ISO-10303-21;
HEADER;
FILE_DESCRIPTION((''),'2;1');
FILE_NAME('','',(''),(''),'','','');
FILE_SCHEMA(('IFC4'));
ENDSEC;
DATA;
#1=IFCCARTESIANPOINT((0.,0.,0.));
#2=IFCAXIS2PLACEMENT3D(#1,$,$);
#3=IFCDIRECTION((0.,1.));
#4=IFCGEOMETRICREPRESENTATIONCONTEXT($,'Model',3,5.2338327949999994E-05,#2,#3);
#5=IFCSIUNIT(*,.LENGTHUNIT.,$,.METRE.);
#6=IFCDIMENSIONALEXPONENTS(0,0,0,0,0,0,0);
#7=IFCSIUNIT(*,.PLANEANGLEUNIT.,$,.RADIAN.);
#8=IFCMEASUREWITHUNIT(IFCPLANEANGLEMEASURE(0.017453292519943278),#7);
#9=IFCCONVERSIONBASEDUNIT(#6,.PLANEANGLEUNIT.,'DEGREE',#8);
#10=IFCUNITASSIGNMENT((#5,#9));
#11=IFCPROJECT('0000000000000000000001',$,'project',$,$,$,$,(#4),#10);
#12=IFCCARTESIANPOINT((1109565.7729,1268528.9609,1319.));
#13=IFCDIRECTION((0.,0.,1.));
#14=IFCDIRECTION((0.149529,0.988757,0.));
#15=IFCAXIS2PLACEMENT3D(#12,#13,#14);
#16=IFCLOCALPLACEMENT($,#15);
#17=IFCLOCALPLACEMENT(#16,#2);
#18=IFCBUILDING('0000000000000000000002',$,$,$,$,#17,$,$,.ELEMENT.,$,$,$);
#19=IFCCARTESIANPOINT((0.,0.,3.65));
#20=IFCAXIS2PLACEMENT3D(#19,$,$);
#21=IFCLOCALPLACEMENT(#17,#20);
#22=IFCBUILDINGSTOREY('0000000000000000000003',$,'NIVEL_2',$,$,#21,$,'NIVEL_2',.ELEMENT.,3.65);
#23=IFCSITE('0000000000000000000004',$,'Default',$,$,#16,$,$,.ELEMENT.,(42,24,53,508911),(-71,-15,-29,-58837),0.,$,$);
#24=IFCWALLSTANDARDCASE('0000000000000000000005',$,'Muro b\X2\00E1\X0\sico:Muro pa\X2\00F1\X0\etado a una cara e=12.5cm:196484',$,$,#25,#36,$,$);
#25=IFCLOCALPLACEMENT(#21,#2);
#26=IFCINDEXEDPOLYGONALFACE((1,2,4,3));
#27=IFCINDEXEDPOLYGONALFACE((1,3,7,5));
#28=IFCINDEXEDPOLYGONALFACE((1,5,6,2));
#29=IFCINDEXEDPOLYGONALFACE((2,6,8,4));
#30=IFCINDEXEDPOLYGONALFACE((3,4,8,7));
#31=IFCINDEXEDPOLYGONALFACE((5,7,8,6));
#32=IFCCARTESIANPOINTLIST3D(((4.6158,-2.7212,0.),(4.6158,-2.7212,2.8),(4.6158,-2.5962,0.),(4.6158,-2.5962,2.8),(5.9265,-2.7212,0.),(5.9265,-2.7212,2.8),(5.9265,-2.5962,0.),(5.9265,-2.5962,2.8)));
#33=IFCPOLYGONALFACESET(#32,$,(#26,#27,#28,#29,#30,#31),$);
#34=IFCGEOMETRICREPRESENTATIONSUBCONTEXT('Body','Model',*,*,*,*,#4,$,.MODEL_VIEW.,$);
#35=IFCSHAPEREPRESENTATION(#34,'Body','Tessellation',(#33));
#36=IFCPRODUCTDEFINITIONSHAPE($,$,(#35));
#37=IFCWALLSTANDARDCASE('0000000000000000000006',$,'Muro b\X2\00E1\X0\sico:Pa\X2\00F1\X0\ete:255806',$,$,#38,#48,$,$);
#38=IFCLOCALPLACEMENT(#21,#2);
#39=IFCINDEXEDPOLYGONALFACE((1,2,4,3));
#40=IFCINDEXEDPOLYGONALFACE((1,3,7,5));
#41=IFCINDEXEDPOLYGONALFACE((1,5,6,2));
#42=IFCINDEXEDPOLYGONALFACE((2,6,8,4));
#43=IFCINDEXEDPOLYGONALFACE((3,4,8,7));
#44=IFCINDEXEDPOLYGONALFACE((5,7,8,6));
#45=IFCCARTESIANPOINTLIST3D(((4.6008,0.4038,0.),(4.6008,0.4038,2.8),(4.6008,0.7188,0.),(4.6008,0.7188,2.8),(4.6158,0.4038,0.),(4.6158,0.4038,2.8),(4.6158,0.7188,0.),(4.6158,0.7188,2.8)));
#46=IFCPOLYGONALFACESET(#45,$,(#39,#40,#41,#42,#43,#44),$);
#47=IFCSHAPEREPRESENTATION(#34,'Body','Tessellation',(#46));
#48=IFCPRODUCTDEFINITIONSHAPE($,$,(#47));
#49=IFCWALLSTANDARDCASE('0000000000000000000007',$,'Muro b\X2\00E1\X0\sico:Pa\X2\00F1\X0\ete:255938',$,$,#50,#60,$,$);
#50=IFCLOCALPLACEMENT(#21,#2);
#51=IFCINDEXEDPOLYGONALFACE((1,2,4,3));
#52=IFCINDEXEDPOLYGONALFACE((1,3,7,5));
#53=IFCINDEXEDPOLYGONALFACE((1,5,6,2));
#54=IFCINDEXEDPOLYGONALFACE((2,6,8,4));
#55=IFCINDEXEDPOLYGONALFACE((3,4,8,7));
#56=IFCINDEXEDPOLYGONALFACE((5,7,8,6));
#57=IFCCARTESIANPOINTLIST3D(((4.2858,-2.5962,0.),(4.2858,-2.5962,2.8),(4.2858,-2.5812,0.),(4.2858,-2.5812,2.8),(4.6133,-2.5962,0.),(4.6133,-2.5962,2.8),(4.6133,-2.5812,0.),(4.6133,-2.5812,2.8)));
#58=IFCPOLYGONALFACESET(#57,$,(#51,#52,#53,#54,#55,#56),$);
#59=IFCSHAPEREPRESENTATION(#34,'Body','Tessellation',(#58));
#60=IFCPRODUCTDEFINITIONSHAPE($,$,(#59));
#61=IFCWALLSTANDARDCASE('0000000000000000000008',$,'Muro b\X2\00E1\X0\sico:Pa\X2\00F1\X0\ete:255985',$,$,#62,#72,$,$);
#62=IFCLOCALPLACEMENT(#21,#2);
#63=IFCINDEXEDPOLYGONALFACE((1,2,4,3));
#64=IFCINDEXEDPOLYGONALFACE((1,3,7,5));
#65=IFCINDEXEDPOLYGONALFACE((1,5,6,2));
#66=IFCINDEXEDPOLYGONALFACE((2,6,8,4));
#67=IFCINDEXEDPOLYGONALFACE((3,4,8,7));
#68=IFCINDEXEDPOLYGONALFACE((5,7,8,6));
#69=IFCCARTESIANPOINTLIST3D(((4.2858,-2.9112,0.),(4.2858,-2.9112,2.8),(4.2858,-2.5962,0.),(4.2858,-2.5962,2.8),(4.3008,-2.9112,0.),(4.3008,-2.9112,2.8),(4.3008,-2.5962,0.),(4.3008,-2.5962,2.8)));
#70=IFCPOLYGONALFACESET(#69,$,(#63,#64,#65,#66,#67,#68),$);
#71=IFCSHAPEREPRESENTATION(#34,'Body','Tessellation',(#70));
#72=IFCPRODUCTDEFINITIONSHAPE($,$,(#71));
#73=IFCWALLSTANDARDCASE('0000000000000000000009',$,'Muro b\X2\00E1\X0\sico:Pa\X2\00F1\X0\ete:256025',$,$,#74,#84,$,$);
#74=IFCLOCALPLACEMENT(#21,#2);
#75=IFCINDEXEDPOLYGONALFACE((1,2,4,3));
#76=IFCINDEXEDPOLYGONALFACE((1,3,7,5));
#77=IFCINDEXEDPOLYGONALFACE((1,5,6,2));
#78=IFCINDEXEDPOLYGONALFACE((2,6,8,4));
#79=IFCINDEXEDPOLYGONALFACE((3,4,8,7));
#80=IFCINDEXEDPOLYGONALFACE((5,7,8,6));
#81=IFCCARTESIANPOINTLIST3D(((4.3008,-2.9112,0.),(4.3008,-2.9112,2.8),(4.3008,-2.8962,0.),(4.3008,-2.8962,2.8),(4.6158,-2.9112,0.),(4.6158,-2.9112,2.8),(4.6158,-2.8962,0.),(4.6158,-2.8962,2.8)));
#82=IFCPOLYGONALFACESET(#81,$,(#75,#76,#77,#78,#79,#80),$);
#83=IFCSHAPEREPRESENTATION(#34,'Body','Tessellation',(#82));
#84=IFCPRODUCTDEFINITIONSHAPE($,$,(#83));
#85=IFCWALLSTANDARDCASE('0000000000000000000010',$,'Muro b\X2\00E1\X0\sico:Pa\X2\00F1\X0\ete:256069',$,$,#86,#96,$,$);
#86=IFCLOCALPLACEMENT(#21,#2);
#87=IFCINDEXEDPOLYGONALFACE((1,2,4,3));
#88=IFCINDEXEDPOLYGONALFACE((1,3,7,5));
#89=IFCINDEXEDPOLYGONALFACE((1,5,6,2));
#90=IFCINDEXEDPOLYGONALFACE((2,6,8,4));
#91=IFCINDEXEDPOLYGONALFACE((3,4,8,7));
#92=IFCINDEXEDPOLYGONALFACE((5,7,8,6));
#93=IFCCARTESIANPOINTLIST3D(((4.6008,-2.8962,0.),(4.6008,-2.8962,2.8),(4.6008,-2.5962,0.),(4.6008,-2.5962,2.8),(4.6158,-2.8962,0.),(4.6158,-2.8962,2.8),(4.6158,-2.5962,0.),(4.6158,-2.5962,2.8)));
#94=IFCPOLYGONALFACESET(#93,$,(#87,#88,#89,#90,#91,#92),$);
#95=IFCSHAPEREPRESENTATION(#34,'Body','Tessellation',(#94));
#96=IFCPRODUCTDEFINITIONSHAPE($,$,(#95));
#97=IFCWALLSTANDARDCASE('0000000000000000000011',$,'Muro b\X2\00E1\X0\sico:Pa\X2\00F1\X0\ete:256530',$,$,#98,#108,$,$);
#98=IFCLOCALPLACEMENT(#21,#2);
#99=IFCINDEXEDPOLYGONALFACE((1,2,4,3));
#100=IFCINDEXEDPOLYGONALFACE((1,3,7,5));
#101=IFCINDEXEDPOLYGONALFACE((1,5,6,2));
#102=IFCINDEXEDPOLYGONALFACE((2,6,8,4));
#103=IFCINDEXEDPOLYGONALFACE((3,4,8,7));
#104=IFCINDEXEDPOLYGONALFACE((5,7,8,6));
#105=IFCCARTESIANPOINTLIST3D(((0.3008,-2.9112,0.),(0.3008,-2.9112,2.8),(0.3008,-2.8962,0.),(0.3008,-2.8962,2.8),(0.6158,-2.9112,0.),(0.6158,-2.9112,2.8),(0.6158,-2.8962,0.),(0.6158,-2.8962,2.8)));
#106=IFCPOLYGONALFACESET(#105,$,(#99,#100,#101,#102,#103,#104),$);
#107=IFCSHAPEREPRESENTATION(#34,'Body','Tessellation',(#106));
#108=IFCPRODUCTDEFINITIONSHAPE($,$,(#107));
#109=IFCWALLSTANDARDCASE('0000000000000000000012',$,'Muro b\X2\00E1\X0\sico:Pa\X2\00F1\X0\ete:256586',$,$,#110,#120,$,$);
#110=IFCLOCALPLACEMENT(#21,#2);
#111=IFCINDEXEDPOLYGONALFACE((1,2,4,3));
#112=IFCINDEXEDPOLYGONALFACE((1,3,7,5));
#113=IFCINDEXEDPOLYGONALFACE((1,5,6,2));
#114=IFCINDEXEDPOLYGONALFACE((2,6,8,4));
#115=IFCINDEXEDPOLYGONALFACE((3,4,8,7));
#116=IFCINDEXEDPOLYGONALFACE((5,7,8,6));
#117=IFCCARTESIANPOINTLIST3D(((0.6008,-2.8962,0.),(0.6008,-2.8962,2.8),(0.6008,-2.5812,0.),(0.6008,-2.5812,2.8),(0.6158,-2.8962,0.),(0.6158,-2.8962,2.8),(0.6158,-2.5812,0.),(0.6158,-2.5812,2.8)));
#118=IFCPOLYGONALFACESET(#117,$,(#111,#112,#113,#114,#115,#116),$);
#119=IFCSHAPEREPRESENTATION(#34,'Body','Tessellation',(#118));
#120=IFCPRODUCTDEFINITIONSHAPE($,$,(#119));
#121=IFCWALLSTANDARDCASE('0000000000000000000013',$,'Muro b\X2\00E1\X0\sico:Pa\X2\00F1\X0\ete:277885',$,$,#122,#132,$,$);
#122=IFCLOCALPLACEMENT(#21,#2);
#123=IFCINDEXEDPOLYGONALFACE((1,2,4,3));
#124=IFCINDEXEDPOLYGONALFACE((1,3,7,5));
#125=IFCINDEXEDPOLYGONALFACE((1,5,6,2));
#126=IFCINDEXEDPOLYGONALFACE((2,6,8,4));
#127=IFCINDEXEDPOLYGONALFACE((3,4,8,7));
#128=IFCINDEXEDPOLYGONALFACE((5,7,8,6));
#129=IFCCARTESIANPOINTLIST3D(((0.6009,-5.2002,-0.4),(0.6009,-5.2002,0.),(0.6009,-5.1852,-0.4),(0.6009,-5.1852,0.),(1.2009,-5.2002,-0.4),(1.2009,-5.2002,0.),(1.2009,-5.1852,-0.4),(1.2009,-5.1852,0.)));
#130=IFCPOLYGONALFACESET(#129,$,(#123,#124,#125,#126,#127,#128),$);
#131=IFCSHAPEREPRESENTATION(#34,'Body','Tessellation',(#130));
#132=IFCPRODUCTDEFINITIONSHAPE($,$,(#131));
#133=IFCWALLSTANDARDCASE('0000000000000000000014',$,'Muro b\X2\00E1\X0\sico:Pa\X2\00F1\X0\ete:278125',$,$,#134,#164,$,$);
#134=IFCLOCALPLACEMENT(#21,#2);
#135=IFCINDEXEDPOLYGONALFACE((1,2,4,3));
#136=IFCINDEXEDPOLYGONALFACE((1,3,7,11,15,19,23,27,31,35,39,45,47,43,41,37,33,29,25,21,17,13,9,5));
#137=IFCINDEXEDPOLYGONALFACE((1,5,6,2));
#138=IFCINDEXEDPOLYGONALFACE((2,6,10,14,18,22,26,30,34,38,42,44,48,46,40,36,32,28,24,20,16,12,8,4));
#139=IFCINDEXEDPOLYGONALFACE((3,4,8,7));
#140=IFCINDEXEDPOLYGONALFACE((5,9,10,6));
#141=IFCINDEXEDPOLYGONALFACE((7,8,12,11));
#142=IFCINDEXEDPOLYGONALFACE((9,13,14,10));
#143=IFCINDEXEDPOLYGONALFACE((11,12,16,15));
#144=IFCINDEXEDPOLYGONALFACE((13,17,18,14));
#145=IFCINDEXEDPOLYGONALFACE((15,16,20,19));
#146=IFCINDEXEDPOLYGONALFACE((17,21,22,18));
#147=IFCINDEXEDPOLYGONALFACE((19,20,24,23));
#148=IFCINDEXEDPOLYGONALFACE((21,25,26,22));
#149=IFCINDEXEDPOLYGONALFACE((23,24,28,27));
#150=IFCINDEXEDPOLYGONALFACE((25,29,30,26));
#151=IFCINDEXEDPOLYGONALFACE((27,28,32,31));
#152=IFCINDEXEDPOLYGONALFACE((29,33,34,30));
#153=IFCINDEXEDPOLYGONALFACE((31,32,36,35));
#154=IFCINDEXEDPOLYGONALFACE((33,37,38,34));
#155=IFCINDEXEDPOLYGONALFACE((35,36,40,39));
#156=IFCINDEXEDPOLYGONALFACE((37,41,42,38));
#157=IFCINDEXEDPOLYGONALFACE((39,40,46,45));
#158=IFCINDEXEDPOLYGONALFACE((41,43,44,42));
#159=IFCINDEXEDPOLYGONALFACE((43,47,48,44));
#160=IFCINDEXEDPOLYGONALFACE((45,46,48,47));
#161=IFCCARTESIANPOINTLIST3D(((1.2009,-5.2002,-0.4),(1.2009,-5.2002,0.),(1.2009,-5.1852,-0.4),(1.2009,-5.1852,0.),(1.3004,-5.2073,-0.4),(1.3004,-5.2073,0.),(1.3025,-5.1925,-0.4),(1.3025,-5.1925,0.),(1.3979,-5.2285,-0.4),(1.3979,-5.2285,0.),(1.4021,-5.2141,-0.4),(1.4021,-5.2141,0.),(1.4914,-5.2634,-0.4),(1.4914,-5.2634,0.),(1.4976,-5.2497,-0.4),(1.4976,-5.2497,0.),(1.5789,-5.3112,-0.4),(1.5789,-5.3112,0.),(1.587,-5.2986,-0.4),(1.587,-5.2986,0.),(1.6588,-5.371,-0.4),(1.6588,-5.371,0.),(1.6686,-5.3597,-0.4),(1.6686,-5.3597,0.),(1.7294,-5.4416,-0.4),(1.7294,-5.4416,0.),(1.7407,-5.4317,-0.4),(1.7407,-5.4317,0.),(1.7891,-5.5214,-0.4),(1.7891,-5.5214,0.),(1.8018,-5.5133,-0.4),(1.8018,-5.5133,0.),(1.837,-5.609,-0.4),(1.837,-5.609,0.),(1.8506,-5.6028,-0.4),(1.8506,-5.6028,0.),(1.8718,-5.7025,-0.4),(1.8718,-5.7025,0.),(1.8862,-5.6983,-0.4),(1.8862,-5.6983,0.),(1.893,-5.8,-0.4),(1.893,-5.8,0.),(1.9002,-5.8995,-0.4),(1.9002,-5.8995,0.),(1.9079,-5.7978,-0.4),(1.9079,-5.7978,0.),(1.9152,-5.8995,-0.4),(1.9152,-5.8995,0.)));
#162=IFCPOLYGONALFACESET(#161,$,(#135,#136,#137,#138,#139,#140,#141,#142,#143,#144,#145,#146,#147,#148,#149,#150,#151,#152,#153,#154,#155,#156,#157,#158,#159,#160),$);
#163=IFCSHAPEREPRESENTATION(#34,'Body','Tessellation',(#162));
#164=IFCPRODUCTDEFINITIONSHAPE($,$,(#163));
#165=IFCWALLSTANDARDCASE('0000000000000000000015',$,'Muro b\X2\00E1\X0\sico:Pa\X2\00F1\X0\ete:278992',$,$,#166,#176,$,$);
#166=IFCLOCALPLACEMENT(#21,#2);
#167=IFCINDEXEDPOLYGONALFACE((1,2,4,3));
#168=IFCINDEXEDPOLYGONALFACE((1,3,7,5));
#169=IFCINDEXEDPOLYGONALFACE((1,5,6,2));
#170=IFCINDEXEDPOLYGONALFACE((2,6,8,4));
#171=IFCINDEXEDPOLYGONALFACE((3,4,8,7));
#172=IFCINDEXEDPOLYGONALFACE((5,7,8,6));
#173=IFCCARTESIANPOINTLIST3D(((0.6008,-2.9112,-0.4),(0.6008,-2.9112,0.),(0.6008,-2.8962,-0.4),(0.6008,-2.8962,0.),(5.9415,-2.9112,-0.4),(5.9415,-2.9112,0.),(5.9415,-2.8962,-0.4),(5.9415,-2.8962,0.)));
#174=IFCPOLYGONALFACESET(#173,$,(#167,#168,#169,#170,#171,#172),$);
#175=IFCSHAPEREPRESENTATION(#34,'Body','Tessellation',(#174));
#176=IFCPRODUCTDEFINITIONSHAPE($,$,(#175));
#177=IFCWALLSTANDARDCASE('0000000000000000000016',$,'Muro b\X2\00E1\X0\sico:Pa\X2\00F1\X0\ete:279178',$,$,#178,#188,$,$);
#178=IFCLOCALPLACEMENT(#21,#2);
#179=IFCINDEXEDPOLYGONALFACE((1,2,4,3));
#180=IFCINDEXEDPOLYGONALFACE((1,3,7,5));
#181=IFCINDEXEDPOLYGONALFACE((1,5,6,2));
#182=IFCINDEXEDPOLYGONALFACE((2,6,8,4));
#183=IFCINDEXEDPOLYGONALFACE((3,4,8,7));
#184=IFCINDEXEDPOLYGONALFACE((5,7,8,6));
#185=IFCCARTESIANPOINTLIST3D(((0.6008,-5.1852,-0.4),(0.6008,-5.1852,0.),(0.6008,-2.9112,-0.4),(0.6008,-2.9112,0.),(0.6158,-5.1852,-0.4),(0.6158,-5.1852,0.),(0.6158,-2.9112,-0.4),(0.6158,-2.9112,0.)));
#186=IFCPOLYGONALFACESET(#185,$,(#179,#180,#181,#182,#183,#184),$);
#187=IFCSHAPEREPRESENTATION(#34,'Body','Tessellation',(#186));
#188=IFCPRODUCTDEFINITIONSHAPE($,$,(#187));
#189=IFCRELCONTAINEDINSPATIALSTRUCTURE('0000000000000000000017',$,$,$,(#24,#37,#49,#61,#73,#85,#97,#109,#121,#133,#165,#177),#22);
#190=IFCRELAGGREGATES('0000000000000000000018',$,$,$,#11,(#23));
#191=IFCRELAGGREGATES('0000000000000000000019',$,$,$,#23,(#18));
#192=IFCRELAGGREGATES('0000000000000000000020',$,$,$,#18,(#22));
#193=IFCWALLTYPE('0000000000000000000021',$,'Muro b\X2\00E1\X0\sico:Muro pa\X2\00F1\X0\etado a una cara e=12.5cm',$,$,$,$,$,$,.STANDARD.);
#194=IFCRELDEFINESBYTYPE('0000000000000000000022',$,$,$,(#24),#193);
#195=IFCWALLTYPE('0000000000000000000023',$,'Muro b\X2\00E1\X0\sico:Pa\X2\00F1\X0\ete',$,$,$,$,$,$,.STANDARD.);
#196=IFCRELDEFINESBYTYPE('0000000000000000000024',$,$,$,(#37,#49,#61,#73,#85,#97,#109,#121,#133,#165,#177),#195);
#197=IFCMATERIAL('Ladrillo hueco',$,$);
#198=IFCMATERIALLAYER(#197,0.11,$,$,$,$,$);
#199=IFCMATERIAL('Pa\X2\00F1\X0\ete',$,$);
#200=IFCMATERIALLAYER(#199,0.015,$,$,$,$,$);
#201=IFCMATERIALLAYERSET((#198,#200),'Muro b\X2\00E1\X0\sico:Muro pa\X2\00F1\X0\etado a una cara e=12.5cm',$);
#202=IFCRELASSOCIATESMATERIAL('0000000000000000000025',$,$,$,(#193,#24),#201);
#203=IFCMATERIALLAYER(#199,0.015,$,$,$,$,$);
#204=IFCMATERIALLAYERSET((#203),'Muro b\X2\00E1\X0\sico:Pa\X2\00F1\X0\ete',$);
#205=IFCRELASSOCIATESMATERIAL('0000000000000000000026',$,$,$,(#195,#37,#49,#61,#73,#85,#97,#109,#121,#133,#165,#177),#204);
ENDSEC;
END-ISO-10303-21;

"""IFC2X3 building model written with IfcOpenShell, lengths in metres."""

from ifc_helpers import new_model, entity, si_unit, converted_unit, direction, frame, frame_2d, origin, place, context, subcontext, project, spatial, polyline, circle_curve, parameter, trimmed, segment, composite_curve, rectangle, outline, extrude, material, layer, layer_set, layer_usage, type_object, element, save


model = new_model("IFC2X3")

# Units and contexts
model_context = context("Model", 3, precision=5.2338327949999994e-05, world=origin(), true_north=direction((0.0, 1.0)))
body_context = subcontext(model_context, "Body", "Model", "MODEL_VIEW")
ifc_project = project(units=[si_unit("LENGTHUNIT", "METRE"), converted_unit("PLANEANGLEUNIT", "DEGREE", entity("IfcPlaneAngleMeasure", 0.017453292519943278), si_unit("PLANEANGLEUNIT", "RADIAN"), dimensions=[0, 0, 0, 0, 0, 0, 0])], contexts=[model_context])

# Site, building, storey
site_placement = place(None, frame((1109565.7729, 1268528.9609, 1319.0), z_axis=(0.0, 0.0, 1.0), x_axis=(0.149529, 0.988757, 0.0)))
site = spatial("IfcSite", under=ifc_project, at=site_placement, Name="Default", CompositionType="ELEMENT", RefLatitude=(42, 24, 53, 508911), RefLongitude=(-71, -15, -29, -58837), RefElevation=0.0)
building_placement = place(site_placement, origin())
building = spatial("IfcBuilding", under=site, at=building_placement, CompositionType="ELEMENT")
storey_placement = place(building_placement, frame((0.0, 0.0, 3.65)))
storey = spatial("IfcBuildingStorey", under=building, at=storey_placement, Name="NIVEL_2", LongName="NIVEL_2", CompositionType="ELEMENT", Elevation=3.65)

# Walls
ifc_material_1 = material(Name="Ladrillo hueco")
ifc_layer_1 = layer(ifc_material_1, 0.11)
ifc_material_2 = material(Name="Pañete")
ifc_layer_2 = layer(ifc_material_2, 0.015)
ifc_layer_set_1 = layer_set([ifc_layer_1, ifc_layer_2], Name="Muro básico:Muro pañetado a una cara e=12.5cm")
ifc_layer_usage_1 = layer_usage(ifc_layer_set_1, "AXIS2", "POSITIVE", -0.0625)
wall_type_1 = type_object("IfcWallType", Name="Muro básico:Muro pañetado a una cara e=12.5cm", PredefinedType="STANDARD", material=ifc_layer_set_1)
wall_1_placement = place(storey_placement, frame((5.9265, -2.6587, 0.0), z_axis=(0.0, 0.0, 1.0), x_axis=(-1.0, 0.000015, 0.0)))
element("IfcWallStandardCase", 1, at=wall_1_placement, inside=storey, type_object=wall_type_1, material=ifc_layer_usage_1, Name="Muro básico:Muro pañetado a una cara e=12.5cm:196484", context=body_context, shape_type="SweptSolid", body=[
    extrude(rectangle(XDim=1.3107, YDim=0.125, at=frame_2d((0.6554, 0.0), x_axis=(-1.0, 0.0))), origin(), (0.0, 0.0, 1.0), 2.8),
])
ifc_layer_3 = layer(ifc_material_2, 0.015)
ifc_layer_set_2 = layer_set([ifc_layer_3], Name="Muro básico:Pañete")
ifc_layer_usage_2 = layer_usage(ifc_layer_set_2, "AXIS2", "POSITIVE", -0.0075)
wall_type_2 = type_object("IfcWallType", Name="Muro básico:Pañete", PredefinedType="STANDARD", material=ifc_layer_set_2)
wall_2_placement = place(storey_placement, frame((4.6083, 0.4038, 0.0), z_axis=(0.0, 0.0, 1.0), x_axis=(0.0, 1.0, 0.0)))
element("IfcWallStandardCase", 2, at=wall_2_placement, inside=storey, type_object=wall_type_2, material=ifc_layer_usage_2, Name="Muro básico:Pañete:255806", context=body_context, shape_type="SweptSolid", body=[
    extrude(rectangle(XDim=0.315, YDim=0.015, at=frame_2d((0.1575, 0.0), x_axis=(-1.0, 0.0))), origin(), (0.0, 0.0, 1.0), 2.8),
])
ifc_layer_usage_3 = layer_usage(ifc_layer_set_2, "AXIS2", "POSITIVE", -0.0075)
wall_3_placement = place(storey_placement, frame((4.6133, -2.5887, 0.0), z_axis=(0.0, 0.0, 1.0), x_axis=(-1.0, 0.0, 0.0)))
element("IfcWallStandardCase", 3, at=wall_3_placement, inside=storey, type_object=wall_type_2, material=ifc_layer_usage_3, Name="Muro básico:Pañete:255938", context=body_context, shape_type="SweptSolid", body=[
    extrude(rectangle(XDim=0.3275, YDim=0.015, at=frame_2d((0.1638, 0.0), x_axis=(-1.0, 0.0))), origin(), (0.0, 0.0, 1.0), 2.8),
])
ifc_layer_usage_4 = layer_usage(ifc_layer_set_2, "AXIS2", "POSITIVE", -0.0075)
wall_4_placement = place(storey_placement, frame((4.2933, -2.5962, 0.0), z_axis=(0.0, 0.0, 1.0), x_axis=(0.0, -1.0, 0.0)))
element("IfcWallStandardCase", 4, at=wall_4_placement, inside=storey, type_object=wall_type_2, material=ifc_layer_usage_4, Name="Muro básico:Pañete:255985", context=body_context, shape_type="SweptSolid", body=[
    extrude(rectangle(XDim=0.315, YDim=0.015, at=frame_2d((0.1575, 0.0), x_axis=(-1.0, 0.0))), origin(), (0.0, 0.0, 1.0), 2.8),
])
ifc_layer_usage_5 = layer_usage(ifc_layer_set_2, "AXIS2", "POSITIVE", -0.0075)
wall_5_placement = place(storey_placement, frame((4.3008, -2.9037, 0.0)))
element("IfcWallStandardCase", 5, at=wall_5_placement, inside=storey, type_object=wall_type_2, material=ifc_layer_usage_5, Name="Muro básico:Pañete:256025", context=body_context, shape_type="SweptSolid", body=[
    extrude(rectangle(XDim=0.315, YDim=0.015, at=frame_2d((0.1575, 0.0), x_axis=(-1.0, 0.0))), origin(), (0.0, 0.0, 1.0), 2.8),
])
ifc_layer_usage_6 = layer_usage(ifc_layer_set_2, "AXIS2", "POSITIVE", -0.0075)
wall_6_placement = place(storey_placement, frame((4.6083, -2.8962, 0.0), z_axis=(0.0, 0.0, 1.0), x_axis=(0.0, 1.0, 0.0)))
element("IfcWallStandardCase", 6, at=wall_6_placement, inside=storey, type_object=wall_type_2, material=ifc_layer_usage_6, Name="Muro básico:Pañete:256069", context=body_context, shape_type="SweptSolid", body=[
    extrude(rectangle(XDim=0.3, YDim=0.015, at=frame_2d((0.15, 0.0), x_axis=(-1.0, 0.0))), origin(), (0.0, 0.0, 1.0), 2.8),
])
ifc_layer_usage_7 = layer_usage(ifc_layer_set_2, "AXIS2", "POSITIVE", -0.0075)
wall_7_placement = place(storey_placement, frame((0.3008, -2.9037, 0.0)))
element("IfcWallStandardCase", 7, at=wall_7_placement, inside=storey, type_object=wall_type_2, material=ifc_layer_usage_7, Name="Muro básico:Pañete:256530", context=body_context, shape_type="SweptSolid", body=[
    extrude(rectangle(XDim=0.315, YDim=0.015, at=frame_2d((0.1575, 0.0), x_axis=(-1.0, 0.0))), origin(), (0.0, 0.0, 1.0), 2.8),
])
ifc_layer_usage_8 = layer_usage(ifc_layer_set_2, "AXIS2", "POSITIVE", -0.0075)
wall_8_placement = place(storey_placement, frame((0.6083, -2.8962, 0.0), z_axis=(0.0, 0.0, 1.0), x_axis=(0.0, 1.0, 0.0)))
element("IfcWallStandardCase", 8, at=wall_8_placement, inside=storey, type_object=wall_type_2, material=ifc_layer_usage_8, Name="Muro básico:Pañete:256586", context=body_context, shape_type="SweptSolid", body=[
    extrude(rectangle(XDim=0.315, YDim=0.015, at=frame_2d((0.1575, 0.0), x_axis=(-1.0, 0.0))), origin(), (0.0, 0.0, 1.0), 2.8),
])

# Walls
ifc_layer_usage_9 = layer_usage(ifc_layer_set_2, "AXIS2", "NEGATIVE", 0.0075)
wall_9_placement = place(storey_placement, frame((0.6009, -5.1927, -0.4)))
element("IfcWallStandardCase", 9, at=wall_9_placement, inside=storey, type_object=wall_type_2, material=ifc_layer_usage_9, Name="Muro básico:Pañete:277885", context=body_context, shape_type="SweptSolid", body=[
    extrude(rectangle(XDim=0.6, YDim=0.015, at=frame_2d((0.3, 0.0), x_axis=(-1.0, 0.0))), origin(), (0.0, 0.0, 1.0), 0.4),
])
ifc_layer_usage_10 = layer_usage(ifc_layer_set_2, "AXIS2", "POSITIVE", -0.0075)
wall_10_placement = place(storey_placement, frame((1.2009, -5.1927, -0.4)))
element("IfcWallStandardCase", 10, at=wall_10_placement, inside=storey, type_object=wall_type_2, material=ifc_layer_usage_10, Name="Muro básico:Pañete:278125", context=body_context, shape_type="SweptSolid", body=[
    extrude(outline(composite_curve([segment(trimmed(circle_curve(frame_2d((0.0, -0.7068), x_axis=(1.0, 0.0)), 0.7143), [parameter(360.0)], [parameter(90.0)], True, "PARAMETER"), True, "CONTINUOUS"), segment(polyline([(0.0, 0.0075), (0.0, -0.0075)]), True, "CONTINUOUS"), segment(trimmed(circle_curve(frame_2d((0.0, -0.7068), x_axis=(1.0, 0.0)), 0.6993), [parameter(0.0)], [parameter(90.0)], True, "PARAMETER"), False, "CONTINUOUS"), segment(polyline([(0.6993, -0.7068), (0.7143, -0.7068)]), True, "CONTINUOUS")], self_intersect=False)), origin(), (0.0, 0.0, 1.0), 0.4),
])
ifc_layer_usage_11 = layer_usage(ifc_layer_set_2, "AXIS2", "NEGATIVE", 0.0075)
wall_11_placement = place(storey_placement, frame((5.9415, -2.9037, -0.4), z_axis=(0.0, 0.0, 1.0), x_axis=(-1.0, 0.0, 0.0)))
element("IfcWallStandardCase", 11, at=wall_11_placement, inside=storey, type_object=wall_type_2, material=ifc_layer_usage_11, Name="Muro básico:Pañete:278992", context=body_context, shape_type="SweptSolid", body=[
    extrude(rectangle(XDim=5.3407, YDim=0.015, at=frame_2d((2.6704, 0.0), x_axis=(-1.0, 0.0))), origin(), (0.0, 0.0, 1.0), 0.4),
])
ifc_layer_usage_12 = layer_usage(ifc_layer_set_2, "AXIS2", "POSITIVE", -0.0075)
wall_12_placement = place(storey_placement, frame((0.6083, -5.1852, -0.4), z_axis=(0.0, 0.0, 1.0), x_axis=(0.0, 1.0, 0.0)))
element("IfcWallStandardCase", 12, at=wall_12_placement, inside=storey, type_object=wall_type_2, material=ifc_layer_usage_12, Name="Muro básico:Pañete:279178", context=body_context, shape_type="SweptSolid", body=[
    extrude(rectangle(XDim=2.274, YDim=0.015, at=frame_2d((1.137, 0.0), x_axis=(-1.0, 0.0))), origin(), (0.0, 0.0, 1.0), 0.4),
])

save(model, "model.ifc")
